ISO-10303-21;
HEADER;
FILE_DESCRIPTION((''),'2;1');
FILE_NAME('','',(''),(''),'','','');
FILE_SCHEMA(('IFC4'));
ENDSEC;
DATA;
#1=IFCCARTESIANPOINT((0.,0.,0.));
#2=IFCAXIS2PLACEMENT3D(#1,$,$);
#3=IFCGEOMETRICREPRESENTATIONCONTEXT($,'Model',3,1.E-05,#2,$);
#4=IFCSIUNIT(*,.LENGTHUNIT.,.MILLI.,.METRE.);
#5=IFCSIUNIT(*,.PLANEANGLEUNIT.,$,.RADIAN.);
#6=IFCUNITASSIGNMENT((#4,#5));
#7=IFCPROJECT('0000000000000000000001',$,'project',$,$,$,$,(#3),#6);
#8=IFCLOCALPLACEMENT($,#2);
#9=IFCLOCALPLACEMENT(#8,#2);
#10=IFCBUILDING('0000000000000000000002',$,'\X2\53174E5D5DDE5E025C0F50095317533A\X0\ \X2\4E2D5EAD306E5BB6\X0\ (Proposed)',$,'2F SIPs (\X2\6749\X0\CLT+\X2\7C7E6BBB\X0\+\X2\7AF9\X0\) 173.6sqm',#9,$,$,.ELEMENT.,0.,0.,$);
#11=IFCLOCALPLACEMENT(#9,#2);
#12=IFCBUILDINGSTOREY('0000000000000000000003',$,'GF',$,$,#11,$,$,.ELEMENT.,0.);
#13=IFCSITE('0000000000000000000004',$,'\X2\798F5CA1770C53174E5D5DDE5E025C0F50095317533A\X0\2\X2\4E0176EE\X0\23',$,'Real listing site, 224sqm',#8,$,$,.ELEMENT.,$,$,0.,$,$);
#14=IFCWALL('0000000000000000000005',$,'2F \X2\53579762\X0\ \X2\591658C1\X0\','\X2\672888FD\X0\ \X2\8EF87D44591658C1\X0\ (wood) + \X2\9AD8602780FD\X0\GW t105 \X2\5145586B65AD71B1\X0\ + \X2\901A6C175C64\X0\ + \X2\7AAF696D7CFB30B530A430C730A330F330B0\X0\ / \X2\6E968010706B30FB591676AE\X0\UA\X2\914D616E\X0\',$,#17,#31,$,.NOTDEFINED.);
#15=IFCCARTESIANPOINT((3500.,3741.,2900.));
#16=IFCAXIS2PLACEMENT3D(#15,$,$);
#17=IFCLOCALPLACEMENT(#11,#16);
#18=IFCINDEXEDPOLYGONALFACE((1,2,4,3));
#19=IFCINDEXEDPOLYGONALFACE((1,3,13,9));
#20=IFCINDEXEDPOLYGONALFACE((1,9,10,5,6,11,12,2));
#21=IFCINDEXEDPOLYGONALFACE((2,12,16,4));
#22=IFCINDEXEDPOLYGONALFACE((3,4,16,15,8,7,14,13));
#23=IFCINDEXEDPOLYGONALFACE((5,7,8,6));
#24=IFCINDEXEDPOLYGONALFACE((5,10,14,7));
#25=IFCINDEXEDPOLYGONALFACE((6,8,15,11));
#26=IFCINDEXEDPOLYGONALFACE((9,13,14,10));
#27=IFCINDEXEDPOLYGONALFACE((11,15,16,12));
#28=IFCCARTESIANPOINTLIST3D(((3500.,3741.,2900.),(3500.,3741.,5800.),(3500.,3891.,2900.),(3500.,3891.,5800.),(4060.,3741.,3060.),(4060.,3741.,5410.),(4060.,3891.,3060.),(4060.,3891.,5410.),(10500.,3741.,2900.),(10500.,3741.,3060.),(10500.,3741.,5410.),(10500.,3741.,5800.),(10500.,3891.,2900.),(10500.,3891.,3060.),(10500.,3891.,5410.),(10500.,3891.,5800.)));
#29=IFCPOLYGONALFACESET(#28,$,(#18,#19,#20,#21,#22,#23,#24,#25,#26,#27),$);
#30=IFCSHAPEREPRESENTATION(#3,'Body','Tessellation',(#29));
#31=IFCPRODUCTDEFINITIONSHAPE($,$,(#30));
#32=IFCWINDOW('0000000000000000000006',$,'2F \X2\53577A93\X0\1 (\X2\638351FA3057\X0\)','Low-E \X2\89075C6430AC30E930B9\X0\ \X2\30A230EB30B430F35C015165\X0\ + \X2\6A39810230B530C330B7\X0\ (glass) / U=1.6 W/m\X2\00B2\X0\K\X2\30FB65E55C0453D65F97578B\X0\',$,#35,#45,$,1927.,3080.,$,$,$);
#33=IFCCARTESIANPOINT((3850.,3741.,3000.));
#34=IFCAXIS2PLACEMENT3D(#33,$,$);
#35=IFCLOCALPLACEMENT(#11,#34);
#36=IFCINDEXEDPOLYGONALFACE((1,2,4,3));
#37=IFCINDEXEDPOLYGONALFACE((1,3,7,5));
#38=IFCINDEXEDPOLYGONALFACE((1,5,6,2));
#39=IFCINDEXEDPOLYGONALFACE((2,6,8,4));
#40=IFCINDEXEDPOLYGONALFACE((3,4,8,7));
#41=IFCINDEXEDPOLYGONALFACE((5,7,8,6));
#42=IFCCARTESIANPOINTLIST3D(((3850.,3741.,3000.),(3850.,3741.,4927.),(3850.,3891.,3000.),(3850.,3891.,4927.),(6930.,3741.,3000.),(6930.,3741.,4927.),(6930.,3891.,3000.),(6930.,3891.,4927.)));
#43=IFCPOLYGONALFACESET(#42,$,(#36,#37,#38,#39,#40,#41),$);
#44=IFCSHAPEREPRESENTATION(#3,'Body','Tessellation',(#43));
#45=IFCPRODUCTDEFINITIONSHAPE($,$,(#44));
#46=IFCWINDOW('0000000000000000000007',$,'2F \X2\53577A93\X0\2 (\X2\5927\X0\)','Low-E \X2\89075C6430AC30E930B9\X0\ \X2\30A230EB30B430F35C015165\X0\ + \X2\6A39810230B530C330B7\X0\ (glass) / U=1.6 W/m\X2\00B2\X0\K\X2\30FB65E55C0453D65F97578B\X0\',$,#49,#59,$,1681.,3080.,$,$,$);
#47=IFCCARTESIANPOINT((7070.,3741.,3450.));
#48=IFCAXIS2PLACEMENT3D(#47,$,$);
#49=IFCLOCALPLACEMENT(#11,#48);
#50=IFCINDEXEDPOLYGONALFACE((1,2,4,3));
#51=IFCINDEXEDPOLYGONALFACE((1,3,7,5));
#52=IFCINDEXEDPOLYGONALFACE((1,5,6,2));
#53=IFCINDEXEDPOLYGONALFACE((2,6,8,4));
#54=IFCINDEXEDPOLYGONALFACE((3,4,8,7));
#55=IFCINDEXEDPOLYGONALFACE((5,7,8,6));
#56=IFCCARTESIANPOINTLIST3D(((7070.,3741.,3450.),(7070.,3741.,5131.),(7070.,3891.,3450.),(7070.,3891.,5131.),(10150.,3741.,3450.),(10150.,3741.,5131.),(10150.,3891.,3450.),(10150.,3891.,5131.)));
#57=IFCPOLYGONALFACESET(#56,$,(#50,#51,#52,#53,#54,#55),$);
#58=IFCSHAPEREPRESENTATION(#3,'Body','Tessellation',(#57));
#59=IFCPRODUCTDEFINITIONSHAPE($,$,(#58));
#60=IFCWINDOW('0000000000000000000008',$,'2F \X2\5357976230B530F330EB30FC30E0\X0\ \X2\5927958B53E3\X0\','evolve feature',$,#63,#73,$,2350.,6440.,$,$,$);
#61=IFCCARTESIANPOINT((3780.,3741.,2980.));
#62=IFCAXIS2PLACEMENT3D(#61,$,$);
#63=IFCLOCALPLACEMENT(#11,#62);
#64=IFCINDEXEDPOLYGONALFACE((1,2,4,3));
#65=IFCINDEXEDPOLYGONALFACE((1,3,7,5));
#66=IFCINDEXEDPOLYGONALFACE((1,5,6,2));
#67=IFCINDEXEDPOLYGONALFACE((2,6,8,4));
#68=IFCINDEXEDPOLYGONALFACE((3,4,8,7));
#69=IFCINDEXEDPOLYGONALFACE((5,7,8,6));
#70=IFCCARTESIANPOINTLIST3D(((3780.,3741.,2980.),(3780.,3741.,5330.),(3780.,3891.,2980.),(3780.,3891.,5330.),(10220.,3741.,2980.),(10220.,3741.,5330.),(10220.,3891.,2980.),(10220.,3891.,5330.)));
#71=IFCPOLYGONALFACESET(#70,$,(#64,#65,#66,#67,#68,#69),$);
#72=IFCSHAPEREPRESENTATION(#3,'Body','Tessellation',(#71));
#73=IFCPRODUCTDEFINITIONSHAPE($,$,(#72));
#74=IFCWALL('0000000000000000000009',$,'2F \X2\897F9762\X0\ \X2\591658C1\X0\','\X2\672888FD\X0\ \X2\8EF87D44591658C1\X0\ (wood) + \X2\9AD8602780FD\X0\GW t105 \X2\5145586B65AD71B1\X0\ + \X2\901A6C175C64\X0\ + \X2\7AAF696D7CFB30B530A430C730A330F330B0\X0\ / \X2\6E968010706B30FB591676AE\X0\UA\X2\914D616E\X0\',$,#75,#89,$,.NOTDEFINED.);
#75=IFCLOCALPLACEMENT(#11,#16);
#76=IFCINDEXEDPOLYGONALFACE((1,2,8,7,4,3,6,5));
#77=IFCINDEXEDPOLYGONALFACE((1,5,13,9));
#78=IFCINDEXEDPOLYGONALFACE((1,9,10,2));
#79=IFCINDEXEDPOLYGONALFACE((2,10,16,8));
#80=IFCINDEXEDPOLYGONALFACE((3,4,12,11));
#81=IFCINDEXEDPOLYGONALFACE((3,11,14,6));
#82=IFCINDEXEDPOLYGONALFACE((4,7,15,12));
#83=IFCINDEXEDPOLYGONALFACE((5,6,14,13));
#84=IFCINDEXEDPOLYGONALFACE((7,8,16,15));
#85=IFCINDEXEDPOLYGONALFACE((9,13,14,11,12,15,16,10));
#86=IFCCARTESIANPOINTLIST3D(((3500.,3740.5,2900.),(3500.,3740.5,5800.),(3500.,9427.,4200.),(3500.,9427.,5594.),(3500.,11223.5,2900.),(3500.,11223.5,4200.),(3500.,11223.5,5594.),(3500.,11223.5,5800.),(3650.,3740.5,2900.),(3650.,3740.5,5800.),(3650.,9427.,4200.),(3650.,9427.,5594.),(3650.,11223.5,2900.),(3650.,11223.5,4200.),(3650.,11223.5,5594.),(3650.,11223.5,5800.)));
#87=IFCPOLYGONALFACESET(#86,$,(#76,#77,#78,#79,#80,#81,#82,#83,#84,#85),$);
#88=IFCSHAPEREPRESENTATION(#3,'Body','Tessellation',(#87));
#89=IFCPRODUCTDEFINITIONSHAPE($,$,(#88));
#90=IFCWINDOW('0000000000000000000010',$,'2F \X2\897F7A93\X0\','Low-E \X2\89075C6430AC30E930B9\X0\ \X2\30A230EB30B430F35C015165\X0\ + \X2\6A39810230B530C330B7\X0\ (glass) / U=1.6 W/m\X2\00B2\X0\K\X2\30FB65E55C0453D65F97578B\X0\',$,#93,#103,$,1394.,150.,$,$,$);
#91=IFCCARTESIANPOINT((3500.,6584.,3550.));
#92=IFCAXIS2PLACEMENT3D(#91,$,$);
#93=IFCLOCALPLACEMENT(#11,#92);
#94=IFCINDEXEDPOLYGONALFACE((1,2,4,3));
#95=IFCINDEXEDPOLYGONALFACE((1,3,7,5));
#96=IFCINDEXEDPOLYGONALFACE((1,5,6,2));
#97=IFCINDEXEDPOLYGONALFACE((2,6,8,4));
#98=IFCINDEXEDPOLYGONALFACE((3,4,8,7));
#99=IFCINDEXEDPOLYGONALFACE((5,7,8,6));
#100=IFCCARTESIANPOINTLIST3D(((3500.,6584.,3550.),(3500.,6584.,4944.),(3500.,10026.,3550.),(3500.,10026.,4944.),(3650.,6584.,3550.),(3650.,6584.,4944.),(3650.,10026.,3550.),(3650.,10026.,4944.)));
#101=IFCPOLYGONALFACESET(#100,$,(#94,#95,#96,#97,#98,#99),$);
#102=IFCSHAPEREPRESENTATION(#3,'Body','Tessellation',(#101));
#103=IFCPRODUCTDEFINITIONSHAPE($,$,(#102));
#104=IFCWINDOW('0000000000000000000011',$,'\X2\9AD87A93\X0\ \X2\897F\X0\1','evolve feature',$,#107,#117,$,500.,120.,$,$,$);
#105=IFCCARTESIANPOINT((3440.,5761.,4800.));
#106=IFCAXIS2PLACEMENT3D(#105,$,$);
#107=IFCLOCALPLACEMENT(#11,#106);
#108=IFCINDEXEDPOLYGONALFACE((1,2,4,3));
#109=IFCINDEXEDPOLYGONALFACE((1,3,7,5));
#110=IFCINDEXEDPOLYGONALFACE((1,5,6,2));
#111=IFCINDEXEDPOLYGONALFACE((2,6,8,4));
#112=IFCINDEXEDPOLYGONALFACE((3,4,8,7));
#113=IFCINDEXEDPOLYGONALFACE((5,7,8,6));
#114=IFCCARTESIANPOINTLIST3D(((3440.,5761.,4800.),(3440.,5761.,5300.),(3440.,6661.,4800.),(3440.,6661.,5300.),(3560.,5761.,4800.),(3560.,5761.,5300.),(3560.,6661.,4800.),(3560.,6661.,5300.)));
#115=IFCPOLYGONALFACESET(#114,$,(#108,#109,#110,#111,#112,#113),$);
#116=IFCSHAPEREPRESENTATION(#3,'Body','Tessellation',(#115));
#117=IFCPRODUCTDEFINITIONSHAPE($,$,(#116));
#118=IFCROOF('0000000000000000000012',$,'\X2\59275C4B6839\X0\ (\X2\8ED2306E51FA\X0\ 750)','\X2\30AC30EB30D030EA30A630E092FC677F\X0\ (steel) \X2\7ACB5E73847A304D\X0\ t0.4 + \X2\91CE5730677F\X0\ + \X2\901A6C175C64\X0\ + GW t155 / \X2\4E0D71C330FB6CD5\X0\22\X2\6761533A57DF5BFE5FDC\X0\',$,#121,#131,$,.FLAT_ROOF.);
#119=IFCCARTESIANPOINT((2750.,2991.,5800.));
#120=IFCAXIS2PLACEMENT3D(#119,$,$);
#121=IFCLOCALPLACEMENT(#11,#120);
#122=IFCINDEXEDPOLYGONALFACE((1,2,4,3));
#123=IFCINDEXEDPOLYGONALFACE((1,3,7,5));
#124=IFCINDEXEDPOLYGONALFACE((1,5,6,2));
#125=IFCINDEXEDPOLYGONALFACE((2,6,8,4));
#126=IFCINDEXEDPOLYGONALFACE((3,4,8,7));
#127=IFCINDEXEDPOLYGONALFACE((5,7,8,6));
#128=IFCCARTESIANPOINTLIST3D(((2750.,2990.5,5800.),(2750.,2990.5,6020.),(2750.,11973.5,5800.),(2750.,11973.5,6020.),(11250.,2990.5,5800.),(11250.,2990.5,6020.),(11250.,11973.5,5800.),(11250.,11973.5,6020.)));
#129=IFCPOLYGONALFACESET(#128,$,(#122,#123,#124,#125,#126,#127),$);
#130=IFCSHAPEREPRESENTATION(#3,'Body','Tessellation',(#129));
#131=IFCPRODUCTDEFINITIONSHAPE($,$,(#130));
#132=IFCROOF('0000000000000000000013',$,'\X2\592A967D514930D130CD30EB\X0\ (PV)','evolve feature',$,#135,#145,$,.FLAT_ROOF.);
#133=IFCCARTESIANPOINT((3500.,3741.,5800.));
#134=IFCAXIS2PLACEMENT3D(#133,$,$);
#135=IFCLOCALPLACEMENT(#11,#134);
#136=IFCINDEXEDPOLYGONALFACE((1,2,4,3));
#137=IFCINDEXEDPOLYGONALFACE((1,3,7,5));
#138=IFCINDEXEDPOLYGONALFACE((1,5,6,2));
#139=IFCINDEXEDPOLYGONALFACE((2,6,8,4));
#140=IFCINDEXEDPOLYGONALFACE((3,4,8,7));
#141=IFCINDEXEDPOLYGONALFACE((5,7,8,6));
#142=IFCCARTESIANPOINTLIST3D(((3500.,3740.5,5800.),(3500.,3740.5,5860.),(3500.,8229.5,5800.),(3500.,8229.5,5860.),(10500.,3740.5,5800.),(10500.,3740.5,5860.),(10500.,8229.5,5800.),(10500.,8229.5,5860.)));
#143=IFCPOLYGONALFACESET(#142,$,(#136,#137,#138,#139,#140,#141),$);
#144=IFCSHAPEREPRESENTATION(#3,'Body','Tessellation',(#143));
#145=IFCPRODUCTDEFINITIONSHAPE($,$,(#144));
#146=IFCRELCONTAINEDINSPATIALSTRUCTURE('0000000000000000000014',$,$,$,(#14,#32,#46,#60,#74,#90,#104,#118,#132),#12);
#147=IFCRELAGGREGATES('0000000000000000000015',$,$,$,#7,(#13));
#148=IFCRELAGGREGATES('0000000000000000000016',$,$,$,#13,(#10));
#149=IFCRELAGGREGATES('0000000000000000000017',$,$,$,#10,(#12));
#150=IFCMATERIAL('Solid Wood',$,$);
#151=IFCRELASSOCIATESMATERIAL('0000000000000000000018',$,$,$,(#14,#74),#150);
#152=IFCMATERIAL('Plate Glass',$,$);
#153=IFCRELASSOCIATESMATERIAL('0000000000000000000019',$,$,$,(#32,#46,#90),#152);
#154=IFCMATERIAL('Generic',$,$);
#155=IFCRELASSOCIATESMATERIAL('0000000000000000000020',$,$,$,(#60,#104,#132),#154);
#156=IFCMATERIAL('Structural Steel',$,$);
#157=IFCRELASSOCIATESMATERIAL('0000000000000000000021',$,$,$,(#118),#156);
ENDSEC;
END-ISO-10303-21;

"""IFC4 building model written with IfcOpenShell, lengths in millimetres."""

from ifc_helpers import new_model, si_unit, frame, frame_2d, origin, place, context, project, spatial, rectangle, extrude, material, element, fill, save


model = new_model("IFC4")

# Units and contexts
model_context = context("Model", 3, precision=1e-05, world=origin())
ifc_project = project(units=[si_unit("LENGTHUNIT", "METRE", prefix="MILLI"), si_unit("PLANEANGLEUNIT", "RADIAN")], contexts=[model_context])

# Site, building, storey
site_placement = place(None, origin())
site = spatial("IfcSite", under=ifc_project, at=site_placement, Name="福岡県北九州市小倉北区2丁目23", ObjectType="Real listing site, 224sqm", CompositionType="ELEMENT", RefElevation=0.0)
building_placement = place(site_placement, origin())
building = spatial("IfcBuilding", under=site, at=building_placement, Name="北九州市小倉北区 中庭の家 (Proposed)", ObjectType="2F SIPs (杉CLT+籾殻+竹) 173.6sqm", CompositionType="ELEMENT", ElevationOfRefHeight=0.0, ElevationOfTerrain=0.0)
storey_placement = place(building_placement, origin())
storey = spatial("IfcBuildingStorey", under=building, at=storey_placement, Name="GF", CompositionType="ELEMENT", Elevation=0.0)

# Shared definitions
ifc_material_1 = material(Name="Solid Wood")
ifc_material_2 = material(Name="Generic")

# Shared definitions
ifc_material_3 = material(Name="Plate Glass")

# Walls, openings, windows
wall_1_placement = place(storey_placement, frame((3500.0, 3741.0, 2900.0)))
wall_1 = element("IfcWall", 1, at=wall_1_placement, inside=storey, material=ifc_material_1, Name="2F 南面 外壁", Description="木製 軸組外壁 (wood) + 高性能GW t105 充填断熱 + 通気層 + 窯業系サイディング / 準耐火・外皮UA配慮", PredefinedType="NOTDEFINED", context=model_context, shape_type="SweptSolid", body=[
    extrude(rectangle(XDim=7000.0, YDim=150.0, at=frame_2d((3500.0, 75.0))), frame((3500.0, 3741.0, 2900.0)), (0.0, 0.0, 1.0), 2900.0),
])
opening_1_placement = place(storey_placement, frame((3850.0, 3741.0, 3000.0)))
opening_1 = element("IfcOpeningElement", 2, at=opening_1_placement, cuts=wall_1, PredefinedType="NOTDEFINED", context=model_context, shape_type="SweptSolid", body=[
    extrude(rectangle(XDim=3080.0, YDim=150.0, at=frame_2d((1540.0, 75.0))), frame((3850.0, 3741.0, 3000.0)), (0.0, 0.0, 1.0), 1927.0),
])
opening_2_placement = place(storey_placement, frame((7070.0, 3741.0, 3450.0)))
opening_2 = element("IfcOpeningElement", 3, at=opening_2_placement, cuts=wall_1, PredefinedType="NOTDEFINED", context=model_context, shape_type="SweptSolid", body=[
    extrude(rectangle(XDim=3080.0, YDim=150.0, at=frame_2d((1540.0, 75.0))), frame((7070.0, 3741.0, 3450.0)), (0.0, 0.0, 1.0), 1681.0),
])
opening_3_placement = place(storey_placement, frame((3780.0, 3741.0, 2980.0)))
opening_3 = element("IfcOpeningElement", 4, at=opening_3_placement, cuts=wall_1, PredefinedType="NOTDEFINED", context=model_context, shape_type="SweptSolid", body=[
    extrude(rectangle(XDim=6440.0, YDim=150.0, at=frame_2d((3220.0, 75.0))), frame((3780.0, 3741.0, 2980.0)), (0.0, 0.0, 1.0), 2350.0),
])
window_1_placement = place(storey_placement, frame((3850.0, 3741.0, 3000.0)))
window_1 = element("IfcWindow", 5, at=window_1_placement, inside=storey, material=ifc_material_3, Name="2F 南窓1 (掃出し)", Description="Low-E 複層ガラス アルゴン封入 + 樹脂サッシ (glass) / U=1.6 W/m²K・日射取得型", OverallHeight=1927.0, OverallWidth=3080.0, context=model_context, shape_type="SweptSolid", body=[
    extrude(rectangle(XDim=3080.0, YDim=150.0, at=frame_2d((1540.0, 75.0))), frame((3850.0, 3741.0, 3000.0)), (0.0, 0.0, 1.0), 1927.0),
])
fill(opening_1, window_1)
window_2_placement = place(storey_placement, frame((7070.0, 3741.0, 3450.0)))
window_2 = element("IfcWindow", 6, at=window_2_placement, inside=storey, material=ifc_material_3, Name="2F 南窓2 (大)", Description="Low-E 複層ガラス アルゴン封入 + 樹脂サッシ (glass) / U=1.6 W/m²K・日射取得型", OverallHeight=1681.0, OverallWidth=3080.0, context=model_context, shape_type="SweptSolid", body=[
    extrude(rectangle(XDim=3080.0, YDim=150.0, at=frame_2d((1540.0, 75.0))), frame((7070.0, 3741.0, 3450.0)), (0.0, 0.0, 1.0), 1681.0),
])
fill(opening_2, window_2)
window_3_placement = place(storey_placement, frame((3780.0, 3741.0, 2980.0)))
window_3 = element("IfcWindow", 7, at=window_3_placement, inside=storey, material=ifc_material_2, Name="2F 南面サンルーム 大開口", Description="evolve feature", OverallHeight=2350.0, OverallWidth=6440.0, context=model_context, shape_type="SweptSolid", body=[
    extrude(rectangle(XDim=6440.0, YDim=150.0, at=frame_2d((3220.0, 75.0))), frame((3780.0, 3741.0, 2980.0)), (0.0, 0.0, 1.0), 2350.0),
])
fill(opening_3, window_3)
wall_2_placement = place(storey_placement, frame((3500.0, 3741.0, 2900.0)))
wall_2 = element("IfcWall", 8, at=wall_2_placement, inside=storey, material=ifc_material_1, Name="2F 西面 外壁", Description="木製 軸組外壁 (wood) + 高性能GW t105 充填断熱 + 通気層 + 窯業系サイディング / 準耐火・外皮UA配慮", PredefinedType="NOTDEFINED", context=model_context, shape_type="SweptSolid", body=[
    extrude(rectangle(XDim=150.0, YDim=7483.0, at=frame_2d((75.0, 3741.0))), frame((3500.0, 3741.0, 2900.0)), (0.0, 0.0, 1.0), 2900.0),
])
opening_4_placement = place(storey_placement, frame((3500.0, 6584.0, 3550.0)))
opening_4 = element("IfcOpeningElement", 9, at=opening_4_placement, cuts=wall_2, PredefinedType="NOTDEFINED", context=model_context, shape_type="SweptSolid", body=[
    extrude(rectangle(XDim=150.0, YDim=3442.0, at=frame_2d((75.0, 1721.0))), frame((3500.0, 6584.0, 3550.0)), (0.0, 0.0, 1.0), 1394.0),
])
opening_5_placement = place(storey_placement, frame((3440.0, 5761.0, 4800.0)))
opening_5 = element("IfcOpeningElement", 10, at=opening_5_placement, cuts=wall_2, PredefinedType="NOTDEFINED", context=model_context, shape_type="SweptSolid", body=[
    extrude(rectangle(XDim=120.0, YDim=900.0, at=frame_2d((60.0, 450.0))), frame((3440.0, 5761.0, 4800.0)), (0.0, 0.0, 1.0), 500.0),
])
window_4_placement = place(storey_placement, frame((3500.0, 6584.0, 3550.0)))
window_4 = element("IfcWindow", 11, at=window_4_placement, inside=storey, material=ifc_material_3, Name="2F 西窓", Description="Low-E 複層ガラス アルゴン封入 + 樹脂サッシ (glass) / U=1.6 W/m²K・日射取得型", OverallHeight=1394.0, OverallWidth=150.0, context=model_context, shape_type="SweptSolid", body=[
    extrude(rectangle(XDim=150.0, YDim=3442.0, at=frame_2d((75.0, 1721.0))), frame((3500.0, 6584.0, 3550.0)), (0.0, 0.0, 1.0), 1394.0),
])
fill(opening_4, window_4)
window_5_placement = place(storey_placement, frame((3440.0, 5761.0, 4800.0)))
window_5 = element("IfcWindow", 12, at=window_5_placement, inside=storey, material=ifc_material_2, Name="高窓 西1", Description="evolve feature", OverallHeight=500.0, OverallWidth=120.0, context=model_context, shape_type="SweptSolid", body=[
    extrude(rectangle(XDim=120.0, YDim=900.0, at=frame_2d((60.0, 450.0))), frame((3440.0, 5761.0, 4800.0)), (0.0, 0.0, 1.0), 500.0),
])
fill(opening_5, window_5)

# Roofs
ifc_material_4 = material(Name="Structural Steel")
roof_1_placement = place(storey_placement, frame((2750.0, 2991.0, 5800.0)))
element("IfcRoof", 13, at=roof_1_placement, inside=storey, material=ifc_material_4, Name="大屋根 (軒の出 750)", Description="ガルバリウム鋼板 (steel) 立平葺き t0.4 + 野地板 + 通気層 + GW t155 / 不燃・法22条区域対応", PredefinedType="FLAT_ROOF", context=model_context, shape_type="SweptSolid", body=[
    extrude(rectangle(XDim=8500.0, YDim=8983.0, at=frame_2d((4250.0, 4491.0))), frame((2750.0, 2991.0, 5800.0)), (0.0, 0.0, 1.0), 220.0),
])
roof_2_placement = place(storey_placement, frame((3500.0, 3741.0, 5800.0)))
element("IfcRoof", 14, at=roof_2_placement, inside=storey, material=ifc_material_2, Name="太陽光パネル (PV)", Description="evolve feature", PredefinedType="FLAT_ROOF", context=model_context, shape_type="SweptSolid", body=[
    extrude(rectangle(XDim=7000.0, YDim=4489.0, at=frame_2d((3500.0, 2244.0))), frame((3500.0, 3741.0, 5800.0)), (0.0, 0.0, 1.0), 60.0),
])

save(model, "model.ifc")
